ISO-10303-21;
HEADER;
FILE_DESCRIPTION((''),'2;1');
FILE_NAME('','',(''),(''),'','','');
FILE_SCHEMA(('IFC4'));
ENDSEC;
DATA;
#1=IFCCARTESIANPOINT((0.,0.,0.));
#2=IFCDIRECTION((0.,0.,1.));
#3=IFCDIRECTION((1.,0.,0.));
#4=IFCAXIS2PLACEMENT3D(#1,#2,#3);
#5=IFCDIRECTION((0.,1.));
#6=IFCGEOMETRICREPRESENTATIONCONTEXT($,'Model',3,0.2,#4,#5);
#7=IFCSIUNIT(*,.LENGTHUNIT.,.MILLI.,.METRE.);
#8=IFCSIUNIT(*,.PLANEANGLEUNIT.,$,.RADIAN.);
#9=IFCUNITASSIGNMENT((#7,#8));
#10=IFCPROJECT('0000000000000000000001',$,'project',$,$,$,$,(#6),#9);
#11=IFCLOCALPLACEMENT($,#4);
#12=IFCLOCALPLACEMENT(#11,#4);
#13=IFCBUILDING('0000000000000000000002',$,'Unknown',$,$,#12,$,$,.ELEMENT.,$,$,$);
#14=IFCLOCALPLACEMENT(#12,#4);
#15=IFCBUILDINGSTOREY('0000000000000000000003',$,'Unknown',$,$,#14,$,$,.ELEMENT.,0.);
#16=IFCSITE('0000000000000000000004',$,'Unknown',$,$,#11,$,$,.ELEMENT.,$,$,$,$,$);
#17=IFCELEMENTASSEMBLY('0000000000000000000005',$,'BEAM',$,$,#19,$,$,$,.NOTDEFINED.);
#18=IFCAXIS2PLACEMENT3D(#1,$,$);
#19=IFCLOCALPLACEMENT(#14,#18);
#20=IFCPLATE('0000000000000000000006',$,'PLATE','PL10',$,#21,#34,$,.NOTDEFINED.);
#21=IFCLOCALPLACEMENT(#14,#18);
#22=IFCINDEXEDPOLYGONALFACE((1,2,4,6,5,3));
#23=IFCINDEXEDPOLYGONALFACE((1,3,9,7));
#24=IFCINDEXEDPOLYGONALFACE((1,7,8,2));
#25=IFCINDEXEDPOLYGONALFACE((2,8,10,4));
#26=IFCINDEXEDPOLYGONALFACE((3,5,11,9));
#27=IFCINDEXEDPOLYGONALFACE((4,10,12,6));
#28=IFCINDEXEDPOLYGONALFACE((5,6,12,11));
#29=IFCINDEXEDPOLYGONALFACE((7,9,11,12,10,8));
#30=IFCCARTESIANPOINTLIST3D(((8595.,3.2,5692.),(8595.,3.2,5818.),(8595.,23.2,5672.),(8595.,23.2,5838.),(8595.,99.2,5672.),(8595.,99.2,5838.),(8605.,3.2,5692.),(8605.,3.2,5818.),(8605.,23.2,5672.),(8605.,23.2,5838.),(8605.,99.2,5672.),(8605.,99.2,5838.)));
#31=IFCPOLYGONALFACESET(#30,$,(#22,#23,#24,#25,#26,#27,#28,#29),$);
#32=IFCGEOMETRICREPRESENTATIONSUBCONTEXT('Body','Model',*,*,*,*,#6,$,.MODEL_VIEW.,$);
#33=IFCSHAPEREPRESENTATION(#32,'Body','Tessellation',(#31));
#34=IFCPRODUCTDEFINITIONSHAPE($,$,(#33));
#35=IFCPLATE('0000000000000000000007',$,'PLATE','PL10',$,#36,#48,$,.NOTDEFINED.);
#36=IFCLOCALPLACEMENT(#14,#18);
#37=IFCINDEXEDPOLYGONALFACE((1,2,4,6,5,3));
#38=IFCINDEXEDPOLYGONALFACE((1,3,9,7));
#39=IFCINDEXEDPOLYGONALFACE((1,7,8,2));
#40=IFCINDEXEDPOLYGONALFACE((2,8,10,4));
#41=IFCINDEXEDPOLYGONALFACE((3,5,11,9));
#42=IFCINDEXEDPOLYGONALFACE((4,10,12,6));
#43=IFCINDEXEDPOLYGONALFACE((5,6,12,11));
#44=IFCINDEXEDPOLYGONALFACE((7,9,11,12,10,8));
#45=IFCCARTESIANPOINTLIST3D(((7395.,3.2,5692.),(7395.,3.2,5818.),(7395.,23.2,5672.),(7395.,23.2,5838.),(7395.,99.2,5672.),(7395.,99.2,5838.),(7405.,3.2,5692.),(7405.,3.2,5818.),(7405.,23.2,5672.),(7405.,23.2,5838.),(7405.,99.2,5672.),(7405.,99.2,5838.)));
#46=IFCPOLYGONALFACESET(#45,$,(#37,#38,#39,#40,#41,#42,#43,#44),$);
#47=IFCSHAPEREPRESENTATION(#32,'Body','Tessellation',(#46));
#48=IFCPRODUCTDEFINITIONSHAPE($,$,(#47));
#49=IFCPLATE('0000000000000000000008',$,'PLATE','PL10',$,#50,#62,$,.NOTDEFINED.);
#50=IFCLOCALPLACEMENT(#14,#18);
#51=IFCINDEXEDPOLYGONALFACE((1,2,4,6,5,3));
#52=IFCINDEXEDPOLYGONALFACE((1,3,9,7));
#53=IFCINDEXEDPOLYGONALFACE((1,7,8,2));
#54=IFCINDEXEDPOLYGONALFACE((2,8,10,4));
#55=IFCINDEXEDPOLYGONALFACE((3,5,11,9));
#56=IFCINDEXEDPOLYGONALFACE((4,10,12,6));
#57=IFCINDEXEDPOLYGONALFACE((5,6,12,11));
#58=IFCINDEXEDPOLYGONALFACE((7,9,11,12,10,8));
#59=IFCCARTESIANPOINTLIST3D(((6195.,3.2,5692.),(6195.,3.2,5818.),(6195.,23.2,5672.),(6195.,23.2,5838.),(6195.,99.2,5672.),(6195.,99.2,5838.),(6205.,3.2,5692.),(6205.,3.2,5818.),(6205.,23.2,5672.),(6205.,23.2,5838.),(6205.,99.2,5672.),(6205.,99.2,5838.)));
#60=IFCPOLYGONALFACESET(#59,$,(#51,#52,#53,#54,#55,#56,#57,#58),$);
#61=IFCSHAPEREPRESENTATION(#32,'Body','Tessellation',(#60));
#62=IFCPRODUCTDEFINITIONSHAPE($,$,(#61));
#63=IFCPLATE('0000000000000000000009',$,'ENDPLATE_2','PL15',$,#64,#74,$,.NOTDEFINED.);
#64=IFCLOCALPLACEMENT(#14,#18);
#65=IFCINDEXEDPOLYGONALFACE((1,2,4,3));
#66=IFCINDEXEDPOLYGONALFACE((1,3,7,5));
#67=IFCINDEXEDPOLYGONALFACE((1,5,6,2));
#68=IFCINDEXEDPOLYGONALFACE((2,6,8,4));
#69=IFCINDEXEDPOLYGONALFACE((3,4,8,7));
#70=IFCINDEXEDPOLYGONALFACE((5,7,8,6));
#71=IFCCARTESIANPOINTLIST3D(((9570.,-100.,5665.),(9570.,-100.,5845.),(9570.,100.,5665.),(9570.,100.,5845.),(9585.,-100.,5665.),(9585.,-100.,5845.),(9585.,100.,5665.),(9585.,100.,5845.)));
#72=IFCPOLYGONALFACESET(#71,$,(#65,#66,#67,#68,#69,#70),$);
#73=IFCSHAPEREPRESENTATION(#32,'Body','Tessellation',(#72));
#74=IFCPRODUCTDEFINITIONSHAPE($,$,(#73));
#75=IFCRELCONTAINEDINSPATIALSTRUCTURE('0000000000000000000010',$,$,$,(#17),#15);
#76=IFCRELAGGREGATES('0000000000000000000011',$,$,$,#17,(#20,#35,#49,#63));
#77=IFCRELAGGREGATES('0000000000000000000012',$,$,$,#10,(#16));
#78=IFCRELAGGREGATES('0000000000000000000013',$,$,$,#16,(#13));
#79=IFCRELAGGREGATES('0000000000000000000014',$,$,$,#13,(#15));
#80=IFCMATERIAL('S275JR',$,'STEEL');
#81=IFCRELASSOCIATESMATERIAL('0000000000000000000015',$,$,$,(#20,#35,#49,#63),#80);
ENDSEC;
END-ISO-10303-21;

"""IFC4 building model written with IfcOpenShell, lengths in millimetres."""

from ifc_helpers import new_model, si_unit, direction, frame, origin_with_axes, place, context, subcontext, project, spatial, line, indexed_curve, outline, extrude, material, element, aggregate, save


model = new_model("IFC4")

# Units and contexts
model_context = context("Model", 3, precision=0.2, world=origin_with_axes(), true_north=direction((0.0, 1.0)))
body_context = subcontext(model_context, "Body", "Model", "MODEL_VIEW")
ifc_project = project(units=[si_unit("LENGTHUNIT", "METRE", prefix="MILLI"), si_unit("PLANEANGLEUNIT", "RADIAN")], contexts=[model_context])

# Site, building, storey
site_placement = place(None, origin_with_axes())
site = spatial("IfcSite", under=ifc_project, at=site_placement, Name="Unknown", CompositionType="ELEMENT")
building_placement = place(site_placement, origin_with_axes())
building = spatial("IfcBuilding", under=site, at=building_placement, Name="Unknown", CompositionType="ELEMENT")
storey_placement = place(building_placement, origin_with_axes())
storey = spatial("IfcBuildingStorey", under=building, at=storey_placement, Name="Unknown", CompositionType="ELEMENT", Elevation=0.0)

# Shared definitions
ifc_material_1 = material(Name="S275JR", Category="STEEL")

# Element assembly
assembly_1_placement = place(storey_placement, frame((9800.0, 0.0, 5755.0), z_axis=(0.0, 1.0, 0.0), x_axis=(-1.0, 0.0, 0.0)))
assembly_1 = element("IfcElementAssembly", 1, at=assembly_1_placement, inside=storey, Name="BEAM", PredefinedType="NOTDEFINED")

# Plates
plate_1_placement = place(assembly_1_placement, frame((1200.0, -83.0, 3.2), z_axis=(-1.0, 0.0, 0.0), x_axis=(0.0, 0.0, 1.0)))
plate_1 = element("IfcPlate", 2, at=plate_1_placement, material=ifc_material_1, Name="PLATE", Description="PL10", PredefinedType="NOTDEFINED", context=body_context, shape_type="SolidModel", body=[
    extrude(outline(indexed_curve([(0.0, 20.0), (20.0, 0.0), (96.0, 0.0), (96.0, 166.0), (20.0, 166.0), (0.0, 146.0)], segments=[line(1, 2, 3, 4, 5, 6, 1)])), frame((0.0, 0.0, 5.0), z_axis=(0.0, 0.0, 1.0), x_axis=(1.0, 0.0, 0.0)), (0.0, -0.000002, -1.0), 10.0),
])
plate_2_placement = place(assembly_1_placement, frame((2400.0, -83.0, 3.2), z_axis=(-1.0, 0.0, 0.0), x_axis=(0.0, 0.0, 1.0)))
plate_2 = element("IfcPlate", 3, at=plate_2_placement, material=ifc_material_1, Name="PLATE", Description="PL10", PredefinedType="NOTDEFINED", context=body_context, shape_type="SolidModel", body=[
    extrude(outline(indexed_curve([(0.0, 20.0), (20.0, 0.0), (96.0, 0.0), (96.0, 166.0), (20.0, 166.0), (0.0, 146.0)], segments=[line(1, 2, 3, 4, 5, 6, 1)])), frame((0.0, 0.0, 5.0), z_axis=(0.0, 0.0, 1.0), x_axis=(1.0, 0.0, 0.0)), (0.0, -0.000002, -1.0), 10.0),
])
plate_3_placement = place(assembly_1_placement, frame((3600.0, -83.0, 3.2), z_axis=(-1.0, 0.0, 0.0), x_axis=(0.0, 0.0, 1.0)))
plate_3 = element("IfcPlate", 4, at=plate_3_placement, material=ifc_material_1, Name="PLATE", Description="PL10", PredefinedType="NOTDEFINED", context=body_context, shape_type="SolidModel", body=[
    extrude(outline(indexed_curve([(0.0, 20.0), (20.0, 0.0), (96.0, 0.0), (96.0, 166.0), (20.0, 166.0), (0.0, 146.0)], segments=[line(1, 2, 3, 4, 5, 6, 1)])), frame((0.0, 0.0, 5.0), z_axis=(0.0, 0.0, 1.0), x_axis=(1.0, 0.0, 0.0)), (0.0, -0.000002, -1.0), 10.0),
])
plate_4_placement = place(assembly_1_placement, frame((222.5, -90.0, -100.0), z_axis=(1.0, 0.0, 0.0), x_axis=(0.0, 1.0, 0.0)))
plate_4 = element("IfcPlate", 5, at=plate_4_placement, material=ifc_material_1, Name="ENDPLATE_2", Description="PL15", PredefinedType="NOTDEFINED", context=body_context, shape_type="SolidModel", body=[
    extrude(outline(indexed_curve([(0.0, 0.0), (180.0, 0.0), (180.0, 200.0), (0.0, 200.0)], segments=[line(1, 2, 3, 4, 1)])), frame((0.0, 0.0, 7.5), z_axis=(0.0, 0.0, 1.0), x_axis=(1.0, 0.0, 0.0)), (0.0, -0.000002, -1.0), 15.0),
])
aggregate(assembly_1, [plate_1, plate_2, plate_3, plate_4])

save(model, "model.ifc")
